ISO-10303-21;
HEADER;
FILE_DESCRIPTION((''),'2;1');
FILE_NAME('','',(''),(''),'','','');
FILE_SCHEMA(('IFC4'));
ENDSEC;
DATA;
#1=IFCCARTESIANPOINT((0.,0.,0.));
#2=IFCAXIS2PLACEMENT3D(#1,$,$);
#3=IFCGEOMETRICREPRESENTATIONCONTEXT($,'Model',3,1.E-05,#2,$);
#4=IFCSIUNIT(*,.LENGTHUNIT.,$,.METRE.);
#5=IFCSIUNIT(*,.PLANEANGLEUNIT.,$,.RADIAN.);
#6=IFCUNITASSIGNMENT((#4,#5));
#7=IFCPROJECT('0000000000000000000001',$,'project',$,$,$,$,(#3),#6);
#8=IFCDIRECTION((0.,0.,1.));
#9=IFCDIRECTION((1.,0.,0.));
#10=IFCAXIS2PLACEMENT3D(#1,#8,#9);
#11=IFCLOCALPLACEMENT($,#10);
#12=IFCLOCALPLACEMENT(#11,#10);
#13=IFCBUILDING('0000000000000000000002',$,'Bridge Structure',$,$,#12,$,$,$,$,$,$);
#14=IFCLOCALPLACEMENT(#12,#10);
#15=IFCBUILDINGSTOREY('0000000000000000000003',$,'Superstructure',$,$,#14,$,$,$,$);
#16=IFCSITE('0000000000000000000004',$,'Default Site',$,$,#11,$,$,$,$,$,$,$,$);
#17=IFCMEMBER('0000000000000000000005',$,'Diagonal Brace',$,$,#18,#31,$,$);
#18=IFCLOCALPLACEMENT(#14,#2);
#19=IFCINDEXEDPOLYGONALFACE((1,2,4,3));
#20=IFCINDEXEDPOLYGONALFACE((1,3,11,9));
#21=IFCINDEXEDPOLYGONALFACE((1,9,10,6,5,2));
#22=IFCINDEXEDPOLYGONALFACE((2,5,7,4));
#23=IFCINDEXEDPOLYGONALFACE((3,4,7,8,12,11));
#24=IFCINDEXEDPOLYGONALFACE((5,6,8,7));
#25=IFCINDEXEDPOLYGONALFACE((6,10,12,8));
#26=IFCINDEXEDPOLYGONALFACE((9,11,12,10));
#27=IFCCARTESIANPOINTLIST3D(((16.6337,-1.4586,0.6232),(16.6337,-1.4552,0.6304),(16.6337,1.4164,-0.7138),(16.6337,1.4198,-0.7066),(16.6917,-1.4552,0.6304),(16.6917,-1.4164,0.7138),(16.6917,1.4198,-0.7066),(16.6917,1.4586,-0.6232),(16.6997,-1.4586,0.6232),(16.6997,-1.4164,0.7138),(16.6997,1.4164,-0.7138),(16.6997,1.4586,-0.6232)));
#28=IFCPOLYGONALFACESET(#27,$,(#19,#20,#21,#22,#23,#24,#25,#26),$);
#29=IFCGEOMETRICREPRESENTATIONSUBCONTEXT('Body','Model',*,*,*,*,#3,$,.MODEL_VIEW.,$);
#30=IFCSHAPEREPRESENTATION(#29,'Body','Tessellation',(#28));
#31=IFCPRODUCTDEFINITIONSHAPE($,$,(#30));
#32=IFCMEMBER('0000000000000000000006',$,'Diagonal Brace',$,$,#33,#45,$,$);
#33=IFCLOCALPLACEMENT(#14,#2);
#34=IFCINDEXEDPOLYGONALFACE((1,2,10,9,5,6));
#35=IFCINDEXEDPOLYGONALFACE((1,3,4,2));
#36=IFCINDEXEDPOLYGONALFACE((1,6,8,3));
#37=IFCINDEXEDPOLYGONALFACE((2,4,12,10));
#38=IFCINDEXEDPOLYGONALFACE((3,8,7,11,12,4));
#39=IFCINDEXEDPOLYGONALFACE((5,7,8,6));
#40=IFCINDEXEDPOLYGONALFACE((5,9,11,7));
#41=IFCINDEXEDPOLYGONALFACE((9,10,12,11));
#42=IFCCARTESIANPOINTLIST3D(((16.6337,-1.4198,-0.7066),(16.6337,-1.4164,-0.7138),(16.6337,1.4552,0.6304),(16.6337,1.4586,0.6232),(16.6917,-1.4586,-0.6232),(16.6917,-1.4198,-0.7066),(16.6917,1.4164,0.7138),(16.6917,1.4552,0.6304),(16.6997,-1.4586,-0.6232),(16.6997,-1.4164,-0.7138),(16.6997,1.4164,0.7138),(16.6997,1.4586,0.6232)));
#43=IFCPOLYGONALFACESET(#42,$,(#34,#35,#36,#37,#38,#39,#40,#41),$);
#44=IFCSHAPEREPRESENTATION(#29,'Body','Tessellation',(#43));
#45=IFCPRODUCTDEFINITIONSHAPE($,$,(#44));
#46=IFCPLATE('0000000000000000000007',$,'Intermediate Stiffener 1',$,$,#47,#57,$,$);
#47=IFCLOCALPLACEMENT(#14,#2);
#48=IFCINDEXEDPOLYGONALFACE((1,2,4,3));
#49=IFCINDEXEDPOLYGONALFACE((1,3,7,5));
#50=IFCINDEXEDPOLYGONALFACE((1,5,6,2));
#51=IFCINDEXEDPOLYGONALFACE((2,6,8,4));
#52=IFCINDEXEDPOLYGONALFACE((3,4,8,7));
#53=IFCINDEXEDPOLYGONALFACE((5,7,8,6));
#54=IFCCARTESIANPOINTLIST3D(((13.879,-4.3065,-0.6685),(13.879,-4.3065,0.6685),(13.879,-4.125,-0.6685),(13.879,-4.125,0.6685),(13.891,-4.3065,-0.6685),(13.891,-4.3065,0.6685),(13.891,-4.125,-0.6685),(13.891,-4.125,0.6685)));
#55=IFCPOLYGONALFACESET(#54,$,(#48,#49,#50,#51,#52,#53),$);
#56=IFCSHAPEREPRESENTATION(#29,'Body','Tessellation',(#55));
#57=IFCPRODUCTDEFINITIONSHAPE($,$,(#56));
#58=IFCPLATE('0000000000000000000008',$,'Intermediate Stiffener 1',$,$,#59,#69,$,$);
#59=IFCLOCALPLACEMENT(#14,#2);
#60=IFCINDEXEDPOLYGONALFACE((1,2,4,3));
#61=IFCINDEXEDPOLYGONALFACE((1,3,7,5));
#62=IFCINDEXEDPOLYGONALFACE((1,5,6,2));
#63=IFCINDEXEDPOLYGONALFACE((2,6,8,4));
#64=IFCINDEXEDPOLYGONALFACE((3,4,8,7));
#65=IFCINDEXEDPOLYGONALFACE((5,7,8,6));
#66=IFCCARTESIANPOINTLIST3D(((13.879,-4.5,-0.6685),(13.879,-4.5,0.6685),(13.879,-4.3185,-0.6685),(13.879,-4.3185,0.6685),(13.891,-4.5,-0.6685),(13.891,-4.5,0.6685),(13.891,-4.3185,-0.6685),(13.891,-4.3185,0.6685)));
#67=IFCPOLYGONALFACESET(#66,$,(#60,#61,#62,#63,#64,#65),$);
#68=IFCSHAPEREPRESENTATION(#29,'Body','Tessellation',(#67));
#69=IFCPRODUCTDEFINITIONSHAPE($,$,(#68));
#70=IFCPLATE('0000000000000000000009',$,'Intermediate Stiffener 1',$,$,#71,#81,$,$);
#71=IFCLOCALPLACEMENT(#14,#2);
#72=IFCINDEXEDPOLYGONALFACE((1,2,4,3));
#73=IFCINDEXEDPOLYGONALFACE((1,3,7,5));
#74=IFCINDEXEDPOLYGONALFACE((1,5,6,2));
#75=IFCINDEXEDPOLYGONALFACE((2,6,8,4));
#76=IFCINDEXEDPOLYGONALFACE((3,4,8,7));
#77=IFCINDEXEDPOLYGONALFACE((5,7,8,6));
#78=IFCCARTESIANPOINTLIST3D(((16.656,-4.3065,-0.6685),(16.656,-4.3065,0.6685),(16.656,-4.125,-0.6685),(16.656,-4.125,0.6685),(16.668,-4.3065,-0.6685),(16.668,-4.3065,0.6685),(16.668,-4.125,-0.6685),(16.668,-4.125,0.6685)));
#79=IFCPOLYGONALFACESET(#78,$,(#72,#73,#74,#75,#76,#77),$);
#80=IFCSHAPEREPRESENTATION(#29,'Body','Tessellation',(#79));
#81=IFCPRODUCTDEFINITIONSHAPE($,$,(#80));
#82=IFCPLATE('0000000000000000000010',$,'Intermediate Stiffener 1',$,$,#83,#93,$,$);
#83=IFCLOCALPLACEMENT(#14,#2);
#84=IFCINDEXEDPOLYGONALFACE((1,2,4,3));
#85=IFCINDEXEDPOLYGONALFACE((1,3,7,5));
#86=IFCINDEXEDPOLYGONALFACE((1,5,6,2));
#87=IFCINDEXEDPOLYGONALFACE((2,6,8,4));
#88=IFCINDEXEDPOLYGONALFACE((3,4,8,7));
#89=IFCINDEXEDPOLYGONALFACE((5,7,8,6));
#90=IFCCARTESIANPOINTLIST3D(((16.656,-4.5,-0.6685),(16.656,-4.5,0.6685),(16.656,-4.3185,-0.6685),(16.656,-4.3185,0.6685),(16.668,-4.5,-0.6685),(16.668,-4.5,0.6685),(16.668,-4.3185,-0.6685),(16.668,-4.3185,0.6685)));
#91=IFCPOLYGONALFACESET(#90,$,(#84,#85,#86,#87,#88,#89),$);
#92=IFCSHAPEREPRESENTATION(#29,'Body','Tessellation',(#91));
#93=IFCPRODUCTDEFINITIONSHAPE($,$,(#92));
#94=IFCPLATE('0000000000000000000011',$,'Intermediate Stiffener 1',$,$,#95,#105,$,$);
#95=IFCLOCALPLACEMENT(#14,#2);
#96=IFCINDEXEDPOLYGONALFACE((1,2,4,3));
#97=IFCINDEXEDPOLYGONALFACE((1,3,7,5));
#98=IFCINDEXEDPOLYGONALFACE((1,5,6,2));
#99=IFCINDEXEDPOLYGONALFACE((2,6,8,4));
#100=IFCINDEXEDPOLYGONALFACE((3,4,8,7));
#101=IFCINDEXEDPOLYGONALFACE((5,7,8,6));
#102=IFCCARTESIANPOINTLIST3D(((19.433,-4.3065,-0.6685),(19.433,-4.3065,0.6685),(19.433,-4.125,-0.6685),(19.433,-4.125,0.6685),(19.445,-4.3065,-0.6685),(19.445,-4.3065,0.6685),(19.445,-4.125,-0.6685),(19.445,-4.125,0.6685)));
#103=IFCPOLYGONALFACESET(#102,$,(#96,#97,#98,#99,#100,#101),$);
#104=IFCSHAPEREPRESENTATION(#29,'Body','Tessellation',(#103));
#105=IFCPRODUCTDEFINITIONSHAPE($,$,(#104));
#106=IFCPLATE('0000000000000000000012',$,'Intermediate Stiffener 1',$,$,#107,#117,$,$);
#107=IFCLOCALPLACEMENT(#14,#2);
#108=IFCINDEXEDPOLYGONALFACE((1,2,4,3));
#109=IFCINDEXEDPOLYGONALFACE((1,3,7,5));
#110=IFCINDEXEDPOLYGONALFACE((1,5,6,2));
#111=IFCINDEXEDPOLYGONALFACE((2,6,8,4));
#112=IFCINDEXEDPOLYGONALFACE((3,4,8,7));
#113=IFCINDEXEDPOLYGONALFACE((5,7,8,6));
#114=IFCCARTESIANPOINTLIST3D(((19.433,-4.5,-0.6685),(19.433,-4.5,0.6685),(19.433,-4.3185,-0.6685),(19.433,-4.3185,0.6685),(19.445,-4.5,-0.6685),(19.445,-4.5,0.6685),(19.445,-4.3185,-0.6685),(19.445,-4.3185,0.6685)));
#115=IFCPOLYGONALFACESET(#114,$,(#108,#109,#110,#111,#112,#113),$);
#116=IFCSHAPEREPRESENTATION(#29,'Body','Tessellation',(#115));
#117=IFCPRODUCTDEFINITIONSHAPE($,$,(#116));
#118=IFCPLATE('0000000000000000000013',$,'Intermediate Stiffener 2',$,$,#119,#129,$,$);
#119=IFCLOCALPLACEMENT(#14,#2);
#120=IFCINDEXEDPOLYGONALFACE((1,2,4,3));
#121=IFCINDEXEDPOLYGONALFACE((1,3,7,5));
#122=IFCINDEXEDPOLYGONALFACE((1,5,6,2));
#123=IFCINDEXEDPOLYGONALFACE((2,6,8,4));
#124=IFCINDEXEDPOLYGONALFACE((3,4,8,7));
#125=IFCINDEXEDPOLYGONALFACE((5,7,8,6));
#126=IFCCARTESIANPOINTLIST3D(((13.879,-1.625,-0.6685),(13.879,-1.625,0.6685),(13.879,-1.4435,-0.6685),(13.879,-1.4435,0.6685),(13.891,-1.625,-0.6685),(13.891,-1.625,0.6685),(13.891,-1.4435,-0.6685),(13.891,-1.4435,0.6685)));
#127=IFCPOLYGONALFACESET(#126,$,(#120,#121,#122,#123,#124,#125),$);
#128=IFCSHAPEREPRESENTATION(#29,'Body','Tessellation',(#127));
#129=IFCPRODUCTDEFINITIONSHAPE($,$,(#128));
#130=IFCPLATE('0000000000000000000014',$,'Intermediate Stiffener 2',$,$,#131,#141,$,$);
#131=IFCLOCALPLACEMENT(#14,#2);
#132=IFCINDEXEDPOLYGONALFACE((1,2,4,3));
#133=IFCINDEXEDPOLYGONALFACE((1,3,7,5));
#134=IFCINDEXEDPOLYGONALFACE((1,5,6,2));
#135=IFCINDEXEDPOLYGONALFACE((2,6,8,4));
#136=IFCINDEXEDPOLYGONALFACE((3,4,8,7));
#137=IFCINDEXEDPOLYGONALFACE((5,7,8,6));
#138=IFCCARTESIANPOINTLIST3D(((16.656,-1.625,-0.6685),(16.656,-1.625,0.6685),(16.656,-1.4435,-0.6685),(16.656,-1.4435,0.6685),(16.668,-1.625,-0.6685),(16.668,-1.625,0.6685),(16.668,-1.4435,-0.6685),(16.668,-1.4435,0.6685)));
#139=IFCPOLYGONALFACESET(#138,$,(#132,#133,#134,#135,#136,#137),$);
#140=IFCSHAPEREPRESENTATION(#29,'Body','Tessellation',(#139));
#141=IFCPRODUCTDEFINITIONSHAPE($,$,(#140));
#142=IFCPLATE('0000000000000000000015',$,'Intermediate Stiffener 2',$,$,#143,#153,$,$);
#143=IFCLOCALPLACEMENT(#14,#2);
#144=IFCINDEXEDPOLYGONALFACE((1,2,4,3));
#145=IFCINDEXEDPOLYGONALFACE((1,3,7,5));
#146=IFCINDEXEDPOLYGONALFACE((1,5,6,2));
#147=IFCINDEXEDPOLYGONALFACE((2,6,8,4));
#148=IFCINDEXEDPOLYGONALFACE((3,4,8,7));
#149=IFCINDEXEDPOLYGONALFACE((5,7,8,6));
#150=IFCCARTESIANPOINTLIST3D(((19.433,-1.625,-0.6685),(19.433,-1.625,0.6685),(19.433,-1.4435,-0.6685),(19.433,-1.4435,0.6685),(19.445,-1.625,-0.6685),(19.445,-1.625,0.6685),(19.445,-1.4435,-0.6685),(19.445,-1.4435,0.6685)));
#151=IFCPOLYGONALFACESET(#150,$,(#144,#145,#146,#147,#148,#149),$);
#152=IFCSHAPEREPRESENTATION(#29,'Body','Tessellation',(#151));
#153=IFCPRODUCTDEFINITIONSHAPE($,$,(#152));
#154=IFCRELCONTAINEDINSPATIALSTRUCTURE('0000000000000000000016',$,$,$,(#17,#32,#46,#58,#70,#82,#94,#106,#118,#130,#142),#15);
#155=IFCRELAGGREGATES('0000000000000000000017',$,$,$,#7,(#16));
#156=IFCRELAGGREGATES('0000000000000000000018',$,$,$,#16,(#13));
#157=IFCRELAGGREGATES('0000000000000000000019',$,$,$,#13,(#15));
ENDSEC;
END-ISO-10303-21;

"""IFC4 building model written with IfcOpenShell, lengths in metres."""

from ifc_helpers import new_model, si_unit, frame, origin, origin_with_axes, origin_2d_with_axis, place, context, subcontext, project, spatial, rectangle, l_section, extrude, element, save


model = new_model("IFC4")

# Units and contexts
model_context = context("Model", 3, precision=1e-05, world=origin())
body_context = subcontext(model_context, "Body", "Model", "MODEL_VIEW")
ifc_project = project(units=[si_unit("LENGTHUNIT", "METRE"), si_unit("PLANEANGLEUNIT", "RADIAN")], contexts=[model_context])

# Site, building, storey
site_placement = place(None, origin_with_axes())
site = spatial("IfcSite", under=ifc_project, at=site_placement, Name="Default Site")
building_placement = place(site_placement, origin_with_axes())
building = spatial("IfcBuilding", under=site, at=building_placement, Name="Bridge Structure")
storey_placement = place(building_placement, origin_with_axes())
storey = spatial("IfcBuildingStorey", under=building, at=storey_placement, Name="Superstructure")

# Members
for number, where, z_axis, x_axis, name in (
    (1, (16.6667, -1.4375, 0.6685), (0.0, 0.906746, -0.421676), (-1.0, 0.0, 0.0), "Diagonal Brace"),
    (2, (16.6667, -1.4375, -0.6685), (0.0, 0.906746, 0.421676), (-1.0, 0.0, 0.0), "Diagonal Brace"),
):
    element("IfcMember", number, at=place(storey_placement, frame(where, z_axis=z_axis, x_axis=x_axis)), inside=storey, Name=name, context=body_context, shape_type="SweptSolid", body=[
        extrude(l_section(Depth=0.1, Width=0.066, Thickness=0.008, at=origin_2d_with_axis()), origin_with_axes(), (0.0, 0.0, 1.0), 3.1707),
    ])

# Plates
for number, where, z_axis, x_axis, name in (
    (3, (13.885, -4.2157, -0.6685), (0.0, 0.0, 1.0), (1.0, 0.0, 0.0), "Intermediate Stiffener 1"),
    (4, (13.885, -4.4093, -0.6685), (0.0, 0.0, 1.0), (1.0, 0.0, 0.0), "Intermediate Stiffener 1"),
    (5, (16.662, -4.2157, -0.6685), (0.0, 0.0, 1.0), (1.0, 0.0, 0.0), "Intermediate Stiffener 1"),
    (6, (16.662, -4.4093, -0.6685), (0.0, 0.0, 1.0), (1.0, 0.0, 0.0), "Intermediate Stiffener 1"),
    (7, (19.439, -4.2157, -0.6685), (0.0, 0.0, 1.0), (1.0, 0.0, 0.0), "Intermediate Stiffener 1"),
    (8, (19.439, -4.4093, -0.6685), (0.0, 0.0, 1.0), (1.0, 0.0, 0.0), "Intermediate Stiffener 1"),
    (9, (13.885, -1.5343, -0.6685), (0.0, 0.0, 1.0), (1.0, 0.0, 0.0), "Intermediate Stiffener 2"),
    (10, (16.662, -1.5343, -0.6685), (0.0, 0.0, 1.0), (1.0, 0.0, 0.0), "Intermediate Stiffener 2"),
    (11, (19.439, -1.5343, -0.6685), (0.0, 0.0, 1.0), (1.0, 0.0, 0.0), "Intermediate Stiffener 2"),
):
    element("IfcPlate", number, at=place(storey_placement, frame(where, z_axis=z_axis, x_axis=x_axis)), inside=storey, Name=name, context=body_context, shape_type="SweptSolid", body=[
        extrude(rectangle(XDim=0.012, YDim=0.1815, at=origin_2d_with_axis()), origin_with_axes(), (0.0, 0.0, 1.0), 1.337),
    ])

save(model, "model.ifc")
